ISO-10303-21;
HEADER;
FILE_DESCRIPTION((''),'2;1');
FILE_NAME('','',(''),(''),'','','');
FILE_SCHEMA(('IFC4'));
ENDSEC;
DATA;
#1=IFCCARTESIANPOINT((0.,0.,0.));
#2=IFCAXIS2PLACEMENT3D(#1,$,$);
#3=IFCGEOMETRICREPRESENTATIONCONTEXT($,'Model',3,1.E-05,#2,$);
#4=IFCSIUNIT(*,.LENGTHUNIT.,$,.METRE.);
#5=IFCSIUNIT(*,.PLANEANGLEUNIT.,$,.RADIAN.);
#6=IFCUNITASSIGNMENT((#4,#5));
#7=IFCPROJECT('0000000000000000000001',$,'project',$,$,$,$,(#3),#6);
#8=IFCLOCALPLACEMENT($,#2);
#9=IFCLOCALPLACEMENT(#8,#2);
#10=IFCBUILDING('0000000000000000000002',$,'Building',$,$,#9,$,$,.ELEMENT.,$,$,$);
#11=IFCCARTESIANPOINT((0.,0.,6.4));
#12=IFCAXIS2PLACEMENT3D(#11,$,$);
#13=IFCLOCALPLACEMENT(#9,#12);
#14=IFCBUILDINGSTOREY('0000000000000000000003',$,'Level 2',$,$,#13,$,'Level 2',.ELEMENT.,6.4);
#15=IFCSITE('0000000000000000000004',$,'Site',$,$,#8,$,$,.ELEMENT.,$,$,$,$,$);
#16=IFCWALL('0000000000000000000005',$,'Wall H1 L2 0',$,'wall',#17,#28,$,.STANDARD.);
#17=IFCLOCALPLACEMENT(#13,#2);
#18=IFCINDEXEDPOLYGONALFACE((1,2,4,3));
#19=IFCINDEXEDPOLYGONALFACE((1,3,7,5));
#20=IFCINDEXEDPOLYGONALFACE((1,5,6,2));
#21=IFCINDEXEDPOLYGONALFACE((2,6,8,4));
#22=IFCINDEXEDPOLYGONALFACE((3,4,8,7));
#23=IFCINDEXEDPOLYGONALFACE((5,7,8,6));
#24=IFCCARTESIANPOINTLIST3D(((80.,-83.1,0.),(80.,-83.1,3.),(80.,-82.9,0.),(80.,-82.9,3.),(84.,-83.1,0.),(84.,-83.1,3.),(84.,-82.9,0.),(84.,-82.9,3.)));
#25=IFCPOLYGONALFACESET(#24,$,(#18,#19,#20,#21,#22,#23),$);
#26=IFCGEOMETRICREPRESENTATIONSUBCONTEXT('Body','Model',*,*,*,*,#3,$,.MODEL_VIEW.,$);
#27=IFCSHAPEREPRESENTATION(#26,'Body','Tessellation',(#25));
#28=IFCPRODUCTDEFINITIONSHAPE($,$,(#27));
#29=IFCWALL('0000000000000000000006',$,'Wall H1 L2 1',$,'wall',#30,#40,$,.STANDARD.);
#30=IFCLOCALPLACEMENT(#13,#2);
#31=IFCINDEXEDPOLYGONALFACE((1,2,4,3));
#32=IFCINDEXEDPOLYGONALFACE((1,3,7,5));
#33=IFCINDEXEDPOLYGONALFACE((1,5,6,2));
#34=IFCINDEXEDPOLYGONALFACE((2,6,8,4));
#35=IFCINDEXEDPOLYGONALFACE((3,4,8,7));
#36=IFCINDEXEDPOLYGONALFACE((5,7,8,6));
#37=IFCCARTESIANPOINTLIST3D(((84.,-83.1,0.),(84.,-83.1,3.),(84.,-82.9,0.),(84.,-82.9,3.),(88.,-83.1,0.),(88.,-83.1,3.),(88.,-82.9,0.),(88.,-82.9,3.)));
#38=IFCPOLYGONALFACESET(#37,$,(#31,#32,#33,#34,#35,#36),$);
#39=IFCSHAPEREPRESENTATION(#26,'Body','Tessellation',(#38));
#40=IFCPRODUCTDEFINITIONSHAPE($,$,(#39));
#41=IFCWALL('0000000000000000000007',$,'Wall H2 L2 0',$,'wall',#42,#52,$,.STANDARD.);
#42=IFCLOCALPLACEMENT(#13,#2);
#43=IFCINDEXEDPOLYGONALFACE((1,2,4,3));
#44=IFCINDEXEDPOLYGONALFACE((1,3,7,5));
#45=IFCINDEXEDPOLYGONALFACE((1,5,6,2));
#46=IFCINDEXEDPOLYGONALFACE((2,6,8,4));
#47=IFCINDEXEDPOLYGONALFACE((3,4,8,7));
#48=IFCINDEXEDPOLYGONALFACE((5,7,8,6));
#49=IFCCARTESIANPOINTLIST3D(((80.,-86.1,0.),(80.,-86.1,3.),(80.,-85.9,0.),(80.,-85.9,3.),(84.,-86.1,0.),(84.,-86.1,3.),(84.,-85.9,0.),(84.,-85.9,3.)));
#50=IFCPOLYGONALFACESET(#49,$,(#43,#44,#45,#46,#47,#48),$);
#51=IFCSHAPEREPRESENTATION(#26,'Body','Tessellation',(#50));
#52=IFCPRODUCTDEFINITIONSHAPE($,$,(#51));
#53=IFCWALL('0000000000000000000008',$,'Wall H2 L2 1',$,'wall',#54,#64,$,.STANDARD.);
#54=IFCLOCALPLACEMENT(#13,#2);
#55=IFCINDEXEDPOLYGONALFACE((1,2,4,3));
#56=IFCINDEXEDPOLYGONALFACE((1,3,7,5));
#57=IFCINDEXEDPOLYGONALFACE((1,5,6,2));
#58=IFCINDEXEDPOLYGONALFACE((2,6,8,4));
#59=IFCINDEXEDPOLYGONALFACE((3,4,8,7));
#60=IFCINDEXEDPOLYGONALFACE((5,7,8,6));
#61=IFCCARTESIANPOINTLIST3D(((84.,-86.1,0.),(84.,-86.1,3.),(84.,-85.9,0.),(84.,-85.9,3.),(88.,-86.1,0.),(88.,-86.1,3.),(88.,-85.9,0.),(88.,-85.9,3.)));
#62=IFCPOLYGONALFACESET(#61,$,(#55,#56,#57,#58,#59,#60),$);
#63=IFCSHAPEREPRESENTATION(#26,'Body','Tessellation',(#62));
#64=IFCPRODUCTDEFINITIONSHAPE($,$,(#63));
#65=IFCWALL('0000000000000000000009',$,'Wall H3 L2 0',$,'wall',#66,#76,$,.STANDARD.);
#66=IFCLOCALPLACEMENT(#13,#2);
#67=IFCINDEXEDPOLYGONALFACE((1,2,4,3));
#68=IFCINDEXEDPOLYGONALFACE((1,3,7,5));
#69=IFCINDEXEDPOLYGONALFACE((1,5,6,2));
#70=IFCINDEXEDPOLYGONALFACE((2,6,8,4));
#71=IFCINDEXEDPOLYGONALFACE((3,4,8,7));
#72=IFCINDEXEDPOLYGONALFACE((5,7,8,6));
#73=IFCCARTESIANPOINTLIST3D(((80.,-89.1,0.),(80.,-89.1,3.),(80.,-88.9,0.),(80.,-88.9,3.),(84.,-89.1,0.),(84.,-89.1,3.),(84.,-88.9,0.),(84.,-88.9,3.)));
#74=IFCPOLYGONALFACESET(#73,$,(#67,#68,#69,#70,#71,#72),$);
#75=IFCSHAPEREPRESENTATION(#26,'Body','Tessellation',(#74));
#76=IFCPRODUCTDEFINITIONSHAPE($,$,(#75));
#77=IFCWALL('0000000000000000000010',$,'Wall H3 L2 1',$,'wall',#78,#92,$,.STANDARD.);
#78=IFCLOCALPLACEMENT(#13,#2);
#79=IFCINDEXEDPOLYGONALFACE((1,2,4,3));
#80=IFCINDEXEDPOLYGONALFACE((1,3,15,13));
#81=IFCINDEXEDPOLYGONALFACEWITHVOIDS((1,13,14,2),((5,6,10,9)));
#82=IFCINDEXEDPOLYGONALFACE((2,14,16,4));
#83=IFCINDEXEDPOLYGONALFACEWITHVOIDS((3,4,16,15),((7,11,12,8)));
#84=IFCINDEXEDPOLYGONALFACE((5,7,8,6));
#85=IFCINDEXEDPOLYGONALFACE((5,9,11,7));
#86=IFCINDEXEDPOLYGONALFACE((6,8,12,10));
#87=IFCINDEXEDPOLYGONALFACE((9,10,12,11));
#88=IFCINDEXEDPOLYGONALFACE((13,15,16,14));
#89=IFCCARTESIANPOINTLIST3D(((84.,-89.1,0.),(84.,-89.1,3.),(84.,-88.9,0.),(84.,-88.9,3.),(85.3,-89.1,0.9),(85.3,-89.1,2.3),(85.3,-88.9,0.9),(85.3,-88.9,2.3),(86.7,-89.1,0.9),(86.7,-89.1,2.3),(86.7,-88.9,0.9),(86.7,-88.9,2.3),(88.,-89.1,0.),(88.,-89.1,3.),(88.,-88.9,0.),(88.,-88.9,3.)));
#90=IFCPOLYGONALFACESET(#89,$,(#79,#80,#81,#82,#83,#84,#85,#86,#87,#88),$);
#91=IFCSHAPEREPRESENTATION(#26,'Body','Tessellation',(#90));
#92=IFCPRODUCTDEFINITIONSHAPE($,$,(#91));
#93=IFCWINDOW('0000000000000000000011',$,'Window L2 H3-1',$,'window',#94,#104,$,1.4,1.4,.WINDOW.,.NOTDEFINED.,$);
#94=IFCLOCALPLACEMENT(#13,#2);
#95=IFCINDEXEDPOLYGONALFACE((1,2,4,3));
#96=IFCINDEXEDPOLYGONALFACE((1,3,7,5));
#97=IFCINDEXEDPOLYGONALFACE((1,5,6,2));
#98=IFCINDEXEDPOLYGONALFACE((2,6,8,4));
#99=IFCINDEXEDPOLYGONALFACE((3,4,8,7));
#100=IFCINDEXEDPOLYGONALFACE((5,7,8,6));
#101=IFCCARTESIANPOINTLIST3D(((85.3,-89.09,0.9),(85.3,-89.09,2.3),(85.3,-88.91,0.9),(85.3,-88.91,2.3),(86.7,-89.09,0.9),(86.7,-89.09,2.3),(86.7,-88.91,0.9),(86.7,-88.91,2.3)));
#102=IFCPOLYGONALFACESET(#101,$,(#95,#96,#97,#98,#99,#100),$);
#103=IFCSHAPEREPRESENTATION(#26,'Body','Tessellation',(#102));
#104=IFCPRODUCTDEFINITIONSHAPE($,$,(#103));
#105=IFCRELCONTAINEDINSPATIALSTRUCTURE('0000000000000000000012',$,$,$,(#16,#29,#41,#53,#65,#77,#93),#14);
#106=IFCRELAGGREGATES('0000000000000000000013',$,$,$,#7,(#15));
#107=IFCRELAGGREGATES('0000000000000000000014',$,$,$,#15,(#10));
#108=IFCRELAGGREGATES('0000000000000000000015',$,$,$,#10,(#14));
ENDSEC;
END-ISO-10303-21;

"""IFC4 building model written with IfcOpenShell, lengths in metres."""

from ifc_helpers import new_model, si_unit, frame, frame_2d, origin, origin_2d, place, context, subcontext, project, spatial, rectangle, extrude, element, fill, save


model = new_model("IFC4")

# Units and contexts
model_context = context("Model", 3, precision=1e-05, world=origin())
body_context = subcontext(model_context, "Body", "Model", "MODEL_VIEW")
ifc_project = project(units=[si_unit("LENGTHUNIT", "METRE"), si_unit("PLANEANGLEUNIT", "RADIAN")], contexts=[model_context])

# Site, building, storey
site_placement = place(None, origin())
site = spatial("IfcSite", under=ifc_project, at=site_placement, Name="Site", CompositionType="ELEMENT")
building_placement = place(site_placement, origin())
building = spatial("IfcBuilding", under=site, at=building_placement, Name="Building", CompositionType="ELEMENT")
storey_placement = place(building_placement, frame((0.0, 0.0, 6.4)))
storey = spatial("IfcBuildingStorey", under=building, at=storey_placement, Name="Level 2", LongName="Level 2", CompositionType="ELEMENT", Elevation=6.4)

# Walls
for number, where, z_axis, x_axis, name in (
    (1, (80.0, -83.0, 0.0), (0.0, 0.0, 1.0), (1.0, 0.0, 0.0), "Wall H1 L2 0"),
    (2, (84.0, -83.0, 0.0), (0.0, 0.0, 1.0), (1.0, 0.0, 0.0), "Wall H1 L2 1"),
    (3, (80.0, -86.0, 0.0), (0.0, 0.0, 1.0), (1.0, 0.0, 0.0), "Wall H2 L2 0"),
    (4, (84.0, -86.0, 0.0), (0.0, 0.0, 1.0), (1.0, 0.0, 0.0), "Wall H2 L2 1"),
    (5, (80.0, -89.0, 0.0), (0.0, 0.0, 1.0), (1.0, 0.0, 0.0), "Wall H3 L2 0"),
):
    element("IfcWall", number, at=place(storey_placement, frame(where, z_axis=z_axis, x_axis=x_axis)), inside=storey, Name=name, ObjectType="wall", PredefinedType="STANDARD", context=body_context, shape_type="SweptSolid", body=[
        extrude(rectangle(XDim=4.0, YDim=0.2, at=frame_2d((2.0, 0.0))), origin(), (0.0, 0.0, 1.0), 3.0),
    ])

# Wall, opening, window
wall_1_placement = place(storey_placement, frame((84.0, -89.0, 0.0), z_axis=(0.0, 0.0, 1.0), x_axis=(1.0, 0.0, 0.0)))
wall_1 = element("IfcWall", 6, at=wall_1_placement, inside=storey, Name="Wall H3 L2 1", ObjectType="wall", PredefinedType="STANDARD", context=body_context, shape_type="SweptSolid", body=[
    extrude(rectangle(XDim=4.0, YDim=0.2, at=frame_2d((2.0, 0.0))), origin(), (0.0, 0.0, 1.0), 3.0),
])
opening_1_placement = place(storey_placement, frame((86.0, -89.0, 0.9), z_axis=(0.0, 0.0, 1.0), x_axis=(1.0, 0.0, 0.0)))
opening_1 = element("IfcOpeningElement", 7, at=opening_1_placement, cuts=wall_1, ObjectType="Opening", PredefinedType="OPENING", context=body_context, shape_type="SweptSolid", body=[
    extrude(rectangle(XDim=1.4, YDim=0.22, at=origin_2d()), origin(), (0.0, 0.0, 1.0), 1.4),
])
window_1_placement = place(storey_placement, frame((86.0, -89.0, 0.9), z_axis=(0.0, 0.0, 1.0), x_axis=(1.0, 0.0, 0.0)))
window_1 = element("IfcWindow", 8, at=window_1_placement, inside=storey, Name="Window L2 H3-1", ObjectType="window", OverallHeight=1.4, OverallWidth=1.4, PartitioningType="NOTDEFINED", PredefinedType="WINDOW", context=body_context, shape_type="SweptSolid", body=[
    extrude(rectangle(XDim=1.4, YDim=0.18, at=origin_2d()), origin(), (0.0, 0.0, 1.0), 1.4),
])
fill(opening_1, window_1)

save(model, "model.ifc")
